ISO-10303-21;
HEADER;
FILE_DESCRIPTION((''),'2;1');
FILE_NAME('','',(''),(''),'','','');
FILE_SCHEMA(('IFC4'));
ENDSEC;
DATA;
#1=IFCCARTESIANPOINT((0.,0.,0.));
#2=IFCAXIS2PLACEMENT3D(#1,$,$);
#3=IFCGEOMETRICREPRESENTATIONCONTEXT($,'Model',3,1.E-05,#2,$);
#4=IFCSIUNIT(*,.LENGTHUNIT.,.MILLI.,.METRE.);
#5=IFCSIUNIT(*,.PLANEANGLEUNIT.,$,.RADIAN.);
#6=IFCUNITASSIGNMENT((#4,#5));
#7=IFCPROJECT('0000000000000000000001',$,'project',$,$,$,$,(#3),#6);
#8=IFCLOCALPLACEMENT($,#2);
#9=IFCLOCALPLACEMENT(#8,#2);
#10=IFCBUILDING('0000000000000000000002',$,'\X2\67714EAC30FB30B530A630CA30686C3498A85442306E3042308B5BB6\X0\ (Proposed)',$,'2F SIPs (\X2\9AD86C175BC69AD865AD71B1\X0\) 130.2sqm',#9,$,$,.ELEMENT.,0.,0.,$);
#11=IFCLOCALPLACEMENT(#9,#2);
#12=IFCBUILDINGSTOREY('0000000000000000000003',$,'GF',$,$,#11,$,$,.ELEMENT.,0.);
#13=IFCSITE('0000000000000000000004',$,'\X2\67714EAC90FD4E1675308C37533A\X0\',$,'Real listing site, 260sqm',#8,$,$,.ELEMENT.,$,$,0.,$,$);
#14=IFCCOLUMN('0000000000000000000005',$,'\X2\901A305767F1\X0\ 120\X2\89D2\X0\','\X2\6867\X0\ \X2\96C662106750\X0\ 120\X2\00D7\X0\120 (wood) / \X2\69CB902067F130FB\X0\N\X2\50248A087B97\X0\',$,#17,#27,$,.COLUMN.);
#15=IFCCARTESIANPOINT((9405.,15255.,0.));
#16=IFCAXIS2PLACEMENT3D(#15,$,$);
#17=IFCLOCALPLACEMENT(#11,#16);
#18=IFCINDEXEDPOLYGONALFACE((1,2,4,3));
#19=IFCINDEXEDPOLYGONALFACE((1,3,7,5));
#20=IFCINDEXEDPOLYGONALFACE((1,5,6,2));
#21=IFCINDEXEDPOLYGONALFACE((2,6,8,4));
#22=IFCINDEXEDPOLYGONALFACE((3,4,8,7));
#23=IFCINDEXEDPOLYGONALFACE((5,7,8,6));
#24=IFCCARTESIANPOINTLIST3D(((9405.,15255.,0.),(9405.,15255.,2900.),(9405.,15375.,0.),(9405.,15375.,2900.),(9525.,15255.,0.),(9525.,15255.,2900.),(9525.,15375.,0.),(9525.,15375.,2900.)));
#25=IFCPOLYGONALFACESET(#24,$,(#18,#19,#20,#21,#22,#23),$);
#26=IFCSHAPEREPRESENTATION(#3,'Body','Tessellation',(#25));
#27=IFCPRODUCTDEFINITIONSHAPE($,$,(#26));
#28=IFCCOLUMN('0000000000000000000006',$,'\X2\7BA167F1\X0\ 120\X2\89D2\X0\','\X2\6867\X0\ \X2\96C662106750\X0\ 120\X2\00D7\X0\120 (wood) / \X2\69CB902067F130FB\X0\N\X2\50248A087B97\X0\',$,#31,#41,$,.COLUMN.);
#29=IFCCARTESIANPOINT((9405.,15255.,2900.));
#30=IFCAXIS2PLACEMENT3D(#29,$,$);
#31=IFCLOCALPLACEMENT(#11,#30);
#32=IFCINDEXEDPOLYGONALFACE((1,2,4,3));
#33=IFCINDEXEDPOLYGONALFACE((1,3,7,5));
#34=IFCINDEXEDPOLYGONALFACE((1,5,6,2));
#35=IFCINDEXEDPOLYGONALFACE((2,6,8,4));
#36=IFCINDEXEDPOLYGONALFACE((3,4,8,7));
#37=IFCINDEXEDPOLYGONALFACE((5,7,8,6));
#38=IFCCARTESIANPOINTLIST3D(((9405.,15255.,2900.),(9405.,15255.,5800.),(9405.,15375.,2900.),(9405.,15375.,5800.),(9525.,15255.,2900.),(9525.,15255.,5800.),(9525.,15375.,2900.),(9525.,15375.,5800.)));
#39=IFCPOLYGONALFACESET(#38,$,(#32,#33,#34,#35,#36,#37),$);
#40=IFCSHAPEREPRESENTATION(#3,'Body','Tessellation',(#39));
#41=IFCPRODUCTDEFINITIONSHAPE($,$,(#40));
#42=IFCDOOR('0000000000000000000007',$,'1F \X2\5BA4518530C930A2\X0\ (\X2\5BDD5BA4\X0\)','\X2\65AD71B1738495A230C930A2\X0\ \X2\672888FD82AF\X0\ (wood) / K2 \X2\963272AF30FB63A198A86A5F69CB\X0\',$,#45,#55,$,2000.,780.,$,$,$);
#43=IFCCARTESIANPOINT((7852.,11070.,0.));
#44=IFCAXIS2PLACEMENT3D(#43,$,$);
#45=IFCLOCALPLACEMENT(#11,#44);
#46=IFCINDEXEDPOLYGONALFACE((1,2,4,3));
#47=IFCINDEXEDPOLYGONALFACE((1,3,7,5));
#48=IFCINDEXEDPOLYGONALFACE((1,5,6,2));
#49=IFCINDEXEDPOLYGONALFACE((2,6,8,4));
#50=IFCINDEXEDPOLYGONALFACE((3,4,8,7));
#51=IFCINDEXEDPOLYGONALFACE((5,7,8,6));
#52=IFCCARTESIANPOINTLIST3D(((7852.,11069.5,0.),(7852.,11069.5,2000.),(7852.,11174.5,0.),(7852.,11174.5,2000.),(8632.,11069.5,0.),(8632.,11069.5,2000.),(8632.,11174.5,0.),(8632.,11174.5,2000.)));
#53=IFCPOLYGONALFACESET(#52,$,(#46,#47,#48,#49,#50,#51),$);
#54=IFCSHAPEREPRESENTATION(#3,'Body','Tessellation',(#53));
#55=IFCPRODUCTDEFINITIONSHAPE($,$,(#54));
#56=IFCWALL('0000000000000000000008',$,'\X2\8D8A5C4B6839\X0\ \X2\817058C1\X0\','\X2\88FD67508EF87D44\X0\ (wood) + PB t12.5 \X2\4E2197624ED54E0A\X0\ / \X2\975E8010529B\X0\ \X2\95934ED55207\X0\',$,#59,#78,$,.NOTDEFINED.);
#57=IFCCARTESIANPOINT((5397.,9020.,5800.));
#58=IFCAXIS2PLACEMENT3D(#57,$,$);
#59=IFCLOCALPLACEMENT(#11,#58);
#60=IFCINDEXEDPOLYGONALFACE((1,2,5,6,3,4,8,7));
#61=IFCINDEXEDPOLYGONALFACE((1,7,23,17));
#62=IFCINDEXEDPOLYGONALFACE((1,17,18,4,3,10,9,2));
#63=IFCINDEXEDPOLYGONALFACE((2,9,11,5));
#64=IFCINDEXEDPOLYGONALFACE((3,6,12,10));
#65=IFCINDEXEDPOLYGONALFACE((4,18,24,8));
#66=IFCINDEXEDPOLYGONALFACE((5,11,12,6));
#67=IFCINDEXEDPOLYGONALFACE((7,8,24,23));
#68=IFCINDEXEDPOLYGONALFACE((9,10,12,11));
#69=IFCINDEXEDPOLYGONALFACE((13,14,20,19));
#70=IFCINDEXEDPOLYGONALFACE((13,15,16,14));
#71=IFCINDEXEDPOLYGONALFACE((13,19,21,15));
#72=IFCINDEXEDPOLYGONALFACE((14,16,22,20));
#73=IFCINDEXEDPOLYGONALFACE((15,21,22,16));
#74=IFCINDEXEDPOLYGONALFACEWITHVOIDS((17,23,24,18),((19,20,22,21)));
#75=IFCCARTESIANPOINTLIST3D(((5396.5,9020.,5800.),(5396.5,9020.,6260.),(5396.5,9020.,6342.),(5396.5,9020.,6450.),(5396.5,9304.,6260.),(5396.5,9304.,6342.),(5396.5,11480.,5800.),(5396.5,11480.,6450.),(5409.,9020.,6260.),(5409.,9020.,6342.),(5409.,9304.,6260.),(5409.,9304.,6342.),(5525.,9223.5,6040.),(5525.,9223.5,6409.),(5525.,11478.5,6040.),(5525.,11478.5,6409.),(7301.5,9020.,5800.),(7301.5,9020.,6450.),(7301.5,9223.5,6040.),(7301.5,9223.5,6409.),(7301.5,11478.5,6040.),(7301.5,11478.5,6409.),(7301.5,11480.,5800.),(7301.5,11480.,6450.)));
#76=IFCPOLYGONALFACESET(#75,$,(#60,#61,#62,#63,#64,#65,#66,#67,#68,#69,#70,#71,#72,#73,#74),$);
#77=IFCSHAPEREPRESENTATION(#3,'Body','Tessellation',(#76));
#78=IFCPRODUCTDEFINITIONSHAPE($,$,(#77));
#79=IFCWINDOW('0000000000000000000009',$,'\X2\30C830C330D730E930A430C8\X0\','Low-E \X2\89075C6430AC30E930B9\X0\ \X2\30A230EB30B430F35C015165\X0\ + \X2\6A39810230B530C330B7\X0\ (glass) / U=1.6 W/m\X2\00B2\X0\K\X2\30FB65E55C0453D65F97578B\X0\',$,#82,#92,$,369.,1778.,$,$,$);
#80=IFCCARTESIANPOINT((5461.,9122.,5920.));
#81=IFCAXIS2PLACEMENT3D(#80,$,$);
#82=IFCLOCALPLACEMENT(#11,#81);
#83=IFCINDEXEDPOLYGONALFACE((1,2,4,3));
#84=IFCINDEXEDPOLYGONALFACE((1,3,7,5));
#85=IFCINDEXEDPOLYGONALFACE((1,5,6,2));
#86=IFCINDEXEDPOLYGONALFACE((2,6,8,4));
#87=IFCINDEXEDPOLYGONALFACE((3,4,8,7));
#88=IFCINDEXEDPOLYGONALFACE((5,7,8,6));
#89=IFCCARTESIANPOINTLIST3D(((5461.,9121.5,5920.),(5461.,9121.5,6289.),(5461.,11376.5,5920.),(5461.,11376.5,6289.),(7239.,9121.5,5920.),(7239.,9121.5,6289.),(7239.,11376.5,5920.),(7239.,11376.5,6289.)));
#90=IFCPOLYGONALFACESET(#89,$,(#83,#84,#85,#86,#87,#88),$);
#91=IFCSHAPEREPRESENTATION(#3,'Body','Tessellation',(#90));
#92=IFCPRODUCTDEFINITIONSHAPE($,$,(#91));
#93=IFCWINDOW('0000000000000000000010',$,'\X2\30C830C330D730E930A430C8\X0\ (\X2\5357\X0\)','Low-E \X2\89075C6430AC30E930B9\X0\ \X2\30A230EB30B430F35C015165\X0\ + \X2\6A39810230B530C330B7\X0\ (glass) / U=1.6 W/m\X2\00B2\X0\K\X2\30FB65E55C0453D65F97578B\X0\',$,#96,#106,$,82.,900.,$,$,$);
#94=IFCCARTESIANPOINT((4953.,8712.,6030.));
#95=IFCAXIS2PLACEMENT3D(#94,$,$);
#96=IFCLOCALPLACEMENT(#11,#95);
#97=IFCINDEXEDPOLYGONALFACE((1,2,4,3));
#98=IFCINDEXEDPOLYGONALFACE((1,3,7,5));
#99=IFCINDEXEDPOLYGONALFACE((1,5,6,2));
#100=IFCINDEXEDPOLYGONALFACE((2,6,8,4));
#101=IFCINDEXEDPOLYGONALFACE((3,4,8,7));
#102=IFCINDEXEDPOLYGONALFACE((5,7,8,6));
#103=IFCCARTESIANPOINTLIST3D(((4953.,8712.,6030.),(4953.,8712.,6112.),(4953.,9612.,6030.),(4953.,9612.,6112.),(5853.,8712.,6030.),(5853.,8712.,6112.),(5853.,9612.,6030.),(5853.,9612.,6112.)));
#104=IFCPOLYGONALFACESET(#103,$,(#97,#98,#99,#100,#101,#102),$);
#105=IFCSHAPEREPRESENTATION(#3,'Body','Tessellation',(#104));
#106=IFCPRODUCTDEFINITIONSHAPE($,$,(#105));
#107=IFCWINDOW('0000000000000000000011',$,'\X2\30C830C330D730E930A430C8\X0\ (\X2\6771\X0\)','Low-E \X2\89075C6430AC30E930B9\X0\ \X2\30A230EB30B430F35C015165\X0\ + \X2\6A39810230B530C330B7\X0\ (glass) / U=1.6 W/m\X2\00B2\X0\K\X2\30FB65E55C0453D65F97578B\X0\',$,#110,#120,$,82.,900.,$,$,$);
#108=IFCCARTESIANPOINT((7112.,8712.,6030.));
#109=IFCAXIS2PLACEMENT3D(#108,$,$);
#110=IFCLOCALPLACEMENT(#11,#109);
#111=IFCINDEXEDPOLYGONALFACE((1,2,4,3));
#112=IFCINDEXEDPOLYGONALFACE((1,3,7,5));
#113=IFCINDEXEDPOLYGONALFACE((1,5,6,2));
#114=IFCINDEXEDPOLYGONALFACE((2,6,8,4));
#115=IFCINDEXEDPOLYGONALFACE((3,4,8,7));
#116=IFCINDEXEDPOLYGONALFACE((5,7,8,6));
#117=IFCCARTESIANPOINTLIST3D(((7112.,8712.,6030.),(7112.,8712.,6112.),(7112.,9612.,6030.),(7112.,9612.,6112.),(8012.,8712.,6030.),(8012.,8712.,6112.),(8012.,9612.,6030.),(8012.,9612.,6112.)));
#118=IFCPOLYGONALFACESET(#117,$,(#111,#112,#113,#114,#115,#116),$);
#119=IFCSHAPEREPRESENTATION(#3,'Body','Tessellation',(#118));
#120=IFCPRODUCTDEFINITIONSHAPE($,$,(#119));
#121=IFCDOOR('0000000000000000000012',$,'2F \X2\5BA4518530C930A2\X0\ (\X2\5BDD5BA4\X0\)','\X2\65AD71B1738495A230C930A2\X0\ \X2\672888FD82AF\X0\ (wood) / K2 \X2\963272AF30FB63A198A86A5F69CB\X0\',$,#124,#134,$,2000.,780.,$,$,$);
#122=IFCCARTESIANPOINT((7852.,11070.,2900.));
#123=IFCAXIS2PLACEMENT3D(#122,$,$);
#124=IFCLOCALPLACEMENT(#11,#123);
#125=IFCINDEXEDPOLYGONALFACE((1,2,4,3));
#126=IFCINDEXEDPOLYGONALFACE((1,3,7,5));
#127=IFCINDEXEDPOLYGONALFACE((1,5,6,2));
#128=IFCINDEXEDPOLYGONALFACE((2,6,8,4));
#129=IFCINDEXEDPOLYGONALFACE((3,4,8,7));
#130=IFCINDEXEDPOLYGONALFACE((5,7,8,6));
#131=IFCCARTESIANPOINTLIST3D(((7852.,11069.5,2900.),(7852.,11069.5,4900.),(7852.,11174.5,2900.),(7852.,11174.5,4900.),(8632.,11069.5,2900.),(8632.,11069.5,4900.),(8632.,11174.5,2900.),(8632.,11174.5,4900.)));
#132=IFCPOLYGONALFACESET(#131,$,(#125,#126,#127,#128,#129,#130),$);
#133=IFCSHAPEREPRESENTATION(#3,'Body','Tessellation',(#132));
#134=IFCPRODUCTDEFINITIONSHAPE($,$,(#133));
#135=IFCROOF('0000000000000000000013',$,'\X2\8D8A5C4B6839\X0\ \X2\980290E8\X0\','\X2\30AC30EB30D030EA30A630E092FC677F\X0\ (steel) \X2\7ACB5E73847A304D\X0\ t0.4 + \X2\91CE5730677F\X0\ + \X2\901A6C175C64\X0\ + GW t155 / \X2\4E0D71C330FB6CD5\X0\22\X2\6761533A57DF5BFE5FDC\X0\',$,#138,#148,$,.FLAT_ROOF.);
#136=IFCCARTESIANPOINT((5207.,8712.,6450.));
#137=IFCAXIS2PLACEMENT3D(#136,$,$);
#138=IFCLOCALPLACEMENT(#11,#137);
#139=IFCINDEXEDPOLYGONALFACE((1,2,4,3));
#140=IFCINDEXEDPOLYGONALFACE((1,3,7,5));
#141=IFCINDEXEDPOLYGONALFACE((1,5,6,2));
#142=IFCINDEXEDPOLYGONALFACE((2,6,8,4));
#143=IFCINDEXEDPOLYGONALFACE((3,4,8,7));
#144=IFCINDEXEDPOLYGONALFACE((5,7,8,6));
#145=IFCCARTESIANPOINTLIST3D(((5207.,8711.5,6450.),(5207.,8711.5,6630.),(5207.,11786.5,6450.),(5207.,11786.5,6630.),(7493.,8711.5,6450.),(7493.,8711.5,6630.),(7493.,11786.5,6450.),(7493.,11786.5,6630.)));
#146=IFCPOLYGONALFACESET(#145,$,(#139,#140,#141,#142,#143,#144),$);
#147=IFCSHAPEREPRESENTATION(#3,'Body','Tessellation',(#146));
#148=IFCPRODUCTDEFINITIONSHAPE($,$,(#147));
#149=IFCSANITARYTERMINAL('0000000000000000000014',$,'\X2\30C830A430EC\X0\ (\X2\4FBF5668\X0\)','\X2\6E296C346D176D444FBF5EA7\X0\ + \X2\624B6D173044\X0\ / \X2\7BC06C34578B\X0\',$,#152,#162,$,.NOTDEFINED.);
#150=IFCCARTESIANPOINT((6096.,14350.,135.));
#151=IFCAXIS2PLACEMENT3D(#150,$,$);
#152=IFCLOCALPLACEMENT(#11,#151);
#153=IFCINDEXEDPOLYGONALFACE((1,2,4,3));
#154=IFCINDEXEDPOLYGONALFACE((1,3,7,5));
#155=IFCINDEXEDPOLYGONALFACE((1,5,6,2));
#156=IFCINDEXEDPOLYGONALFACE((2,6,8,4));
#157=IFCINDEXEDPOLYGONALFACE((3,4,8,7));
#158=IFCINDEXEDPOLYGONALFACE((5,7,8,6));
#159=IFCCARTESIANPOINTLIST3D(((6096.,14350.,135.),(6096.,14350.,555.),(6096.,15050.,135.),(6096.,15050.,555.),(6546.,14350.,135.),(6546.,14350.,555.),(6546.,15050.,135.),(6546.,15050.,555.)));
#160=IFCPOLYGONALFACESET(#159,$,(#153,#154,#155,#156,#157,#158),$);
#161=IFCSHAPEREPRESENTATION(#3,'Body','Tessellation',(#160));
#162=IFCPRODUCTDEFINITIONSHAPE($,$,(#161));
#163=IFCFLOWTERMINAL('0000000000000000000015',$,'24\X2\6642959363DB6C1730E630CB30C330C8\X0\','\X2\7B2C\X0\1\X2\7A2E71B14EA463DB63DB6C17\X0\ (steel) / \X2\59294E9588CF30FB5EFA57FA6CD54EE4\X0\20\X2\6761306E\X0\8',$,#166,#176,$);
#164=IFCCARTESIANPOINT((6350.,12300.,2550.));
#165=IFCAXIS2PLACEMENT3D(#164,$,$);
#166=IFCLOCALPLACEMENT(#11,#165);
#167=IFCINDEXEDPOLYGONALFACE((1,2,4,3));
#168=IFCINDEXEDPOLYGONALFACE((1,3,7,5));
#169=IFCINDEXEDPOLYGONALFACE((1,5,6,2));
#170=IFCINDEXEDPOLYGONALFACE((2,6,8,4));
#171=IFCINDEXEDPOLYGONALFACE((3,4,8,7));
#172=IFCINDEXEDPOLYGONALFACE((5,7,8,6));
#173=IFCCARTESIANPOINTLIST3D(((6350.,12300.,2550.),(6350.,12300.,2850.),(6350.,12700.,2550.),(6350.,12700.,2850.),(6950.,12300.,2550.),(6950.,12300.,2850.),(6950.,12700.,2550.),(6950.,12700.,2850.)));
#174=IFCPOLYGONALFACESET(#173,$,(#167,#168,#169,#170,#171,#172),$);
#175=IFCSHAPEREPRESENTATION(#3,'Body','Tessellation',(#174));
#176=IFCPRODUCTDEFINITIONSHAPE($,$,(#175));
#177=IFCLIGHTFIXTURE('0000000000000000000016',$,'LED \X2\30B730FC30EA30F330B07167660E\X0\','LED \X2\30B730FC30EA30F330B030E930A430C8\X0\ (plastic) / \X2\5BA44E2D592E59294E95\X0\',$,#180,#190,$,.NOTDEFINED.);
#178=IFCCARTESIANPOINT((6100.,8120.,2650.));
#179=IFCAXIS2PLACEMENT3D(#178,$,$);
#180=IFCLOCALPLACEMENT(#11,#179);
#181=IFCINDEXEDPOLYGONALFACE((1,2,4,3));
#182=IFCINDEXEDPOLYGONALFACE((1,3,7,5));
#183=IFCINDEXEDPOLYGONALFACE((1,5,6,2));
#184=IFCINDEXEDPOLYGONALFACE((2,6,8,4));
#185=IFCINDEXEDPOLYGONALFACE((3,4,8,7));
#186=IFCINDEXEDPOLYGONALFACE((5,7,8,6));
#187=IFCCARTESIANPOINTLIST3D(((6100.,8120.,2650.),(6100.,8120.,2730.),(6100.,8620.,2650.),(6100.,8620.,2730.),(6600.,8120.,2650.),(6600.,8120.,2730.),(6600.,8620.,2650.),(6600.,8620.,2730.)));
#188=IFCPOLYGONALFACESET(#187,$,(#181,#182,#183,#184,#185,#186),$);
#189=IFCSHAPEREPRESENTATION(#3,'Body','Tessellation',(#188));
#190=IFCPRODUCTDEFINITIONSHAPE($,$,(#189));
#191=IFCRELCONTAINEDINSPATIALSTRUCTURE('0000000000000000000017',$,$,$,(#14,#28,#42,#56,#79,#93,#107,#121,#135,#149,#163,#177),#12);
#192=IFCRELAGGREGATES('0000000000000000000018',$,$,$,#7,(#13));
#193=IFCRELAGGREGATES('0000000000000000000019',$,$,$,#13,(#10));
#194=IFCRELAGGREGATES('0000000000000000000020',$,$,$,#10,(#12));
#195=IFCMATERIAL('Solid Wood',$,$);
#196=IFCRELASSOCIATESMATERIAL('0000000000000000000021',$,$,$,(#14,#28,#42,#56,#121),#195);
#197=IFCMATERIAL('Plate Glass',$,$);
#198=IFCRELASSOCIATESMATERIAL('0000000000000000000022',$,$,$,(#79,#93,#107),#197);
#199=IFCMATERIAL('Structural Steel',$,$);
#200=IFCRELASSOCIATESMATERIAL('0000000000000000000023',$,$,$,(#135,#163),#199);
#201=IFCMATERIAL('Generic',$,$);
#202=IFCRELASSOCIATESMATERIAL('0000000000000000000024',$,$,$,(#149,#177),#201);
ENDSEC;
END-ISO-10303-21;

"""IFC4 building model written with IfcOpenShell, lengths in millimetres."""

from ifc_helpers import new_model, si_unit, frame, frame_2d, origin, place, context, project, spatial, rectangle, extrude, material, element, fill, save


model = new_model("IFC4")

# Units and contexts
model_context = context("Model", 3, precision=1e-05, world=origin())
ifc_project = project(units=[si_unit("LENGTHUNIT", "METRE", prefix="MILLI"), si_unit("PLANEANGLEUNIT", "RADIAN")], contexts=[model_context])

# Site, building, storey
site_placement = place(None, origin())
site = spatial("IfcSite", under=ifc_project, at=site_placement, Name="東京都世田谷区", ObjectType="Real listing site, 260sqm", CompositionType="ELEMENT", RefElevation=0.0)
building_placement = place(site_placement, origin())
building = spatial("IfcBuilding", under=site, at=building_placement, Name="東京・サウナと水風呂のある家 (Proposed)", ObjectType="2F SIPs (高気密高断熱) 130.2sqm", CompositionType="ELEMENT", ElevationOfRefHeight=0.0, ElevationOfTerrain=0.0)
storey_placement = place(building_placement, origin())
storey = spatial("IfcBuildingStorey", under=building, at=storey_placement, Name="GF", CompositionType="ELEMENT", Elevation=0.0)

# Columns
ifc_material_1 = material(Name="Solid Wood")
column_1_placement = place(storey_placement, frame((9405.0, 15255.0, 0.0)))
element("IfcColumn", 1, at=column_1_placement, inside=storey, material=ifc_material_1, Name="通し柱 120角", Description="桧 集成材 120×120 (wood) / 構造柱・N値計算", PredefinedType="COLUMN", context=model_context, shape_type="SweptSolid", body=[
    extrude(rectangle(XDim=120.0, YDim=120.0, at=frame_2d((60.0, 60.0))), frame((9405.0, 15255.0, 0.0)), (0.0, 0.0, 1.0), 2900.0),
])
column_2_placement = place(storey_placement, frame((9405.0, 15255.0, 2900.0)))
element("IfcColumn", 2, at=column_2_placement, inside=storey, material=ifc_material_1, Name="管柱 120角", Description="桧 集成材 120×120 (wood) / 構造柱・N値計算", PredefinedType="COLUMN", context=model_context, shape_type="SweptSolid", body=[
    extrude(rectangle(XDim=120.0, YDim=120.0, at=frame_2d((60.0, 60.0))), frame((9405.0, 15255.0, 2900.0)), (0.0, 0.0, 1.0), 2900.0),
])

# Door
door_1_placement = place(storey_placement, frame((7852.0, 11070.0, 0.0)))
element("IfcDoor", 3, at=door_1_placement, inside=storey, material=ifc_material_1, Name="1F 室内ドア (寝室)", Description="断熱玄関ドア 木製芯 (wood) / K2 防犯・採風機構", OverallHeight=2000.0, OverallWidth=780.0, context=model_context, shape_type="SweptSolid", body=[
    extrude(rectangle(XDim=780.0, YDim=105.0, at=frame_2d((390.0, 52.0))), frame((7852.0, 11070.0, 0.0)), (0.0, 0.0, 1.0), 2000.0),
])

# Wall, openings, windows
wall_1_placement = place(storey_placement, frame((5397.0, 9020.0, 5800.0)))
wall_1 = element("IfcWall", 4, at=wall_1_placement, inside=storey, material=ifc_material_1, Name="越屋根 腰壁", Description="製材軸組 (wood) + PB t12.5 両面仕上 / 非耐力 間仕切", PredefinedType="NOTDEFINED", context=model_context, shape_type="SweptSolid", body=[
    extrude(rectangle(XDim=1905.0, YDim=2460.0, at=frame_2d((952.0, 1230.0))), frame((5397.0, 9020.0, 5800.0)), (0.0, 0.0, 1.0), 650.0),
])
opening_1_placement = place(storey_placement, frame((5461.0, 9122.0, 5920.0)))
opening_1 = element("IfcOpeningElement", 5, at=opening_1_placement, cuts=wall_1, PredefinedType="NOTDEFINED", context=model_context, shape_type="SweptSolid", body=[
    extrude(rectangle(XDim=1778.0, YDim=2255.0, at=frame_2d((889.0, 1127.0))), frame((5461.0, 9122.0, 5920.0)), (0.0, 0.0, 1.0), 369.0),
])
opening_2_placement = place(storey_placement, frame((4953.0, 8712.0, 6030.0)))
opening_2 = element("IfcOpeningElement", 6, at=opening_2_placement, cuts=wall_1, PredefinedType="NOTDEFINED", context=model_context, shape_type="SweptSolid", body=[
    extrude(rectangle(XDim=900.0, YDim=900.0, at=frame_2d((450.0, 450.0))), frame((4953.0, 8712.0, 6030.0)), (0.0, 0.0, 1.0), 82.0),
])
opening_3_placement = place(storey_placement, frame((7112.0, 8712.0, 6030.0)))
opening_3 = element("IfcOpeningElement", 7, at=opening_3_placement, cuts=wall_1, PredefinedType="NOTDEFINED", context=model_context, shape_type="SweptSolid", body=[
    extrude(rectangle(XDim=900.0, YDim=900.0, at=frame_2d((450.0, 450.0))), frame((7112.0, 8712.0, 6030.0)), (0.0, 0.0, 1.0), 82.0),
])
ifc_material_2 = material(Name="Plate Glass")
window_1_placement = place(storey_placement, frame((5461.0, 9122.0, 5920.0)))
window_1 = element("IfcWindow", 8, at=window_1_placement, inside=storey, material=ifc_material_2, Name="トップライト", Description="Low-E 複層ガラス アルゴン封入 + 樹脂サッシ (glass) / U=1.6 W/m²K・日射取得型", OverallHeight=369.0, OverallWidth=1778.0, context=model_context, shape_type="SweptSolid", body=[
    extrude(rectangle(XDim=1778.0, YDim=2255.0, at=frame_2d((889.0, 1127.0))), frame((5461.0, 9122.0, 5920.0)), (0.0, 0.0, 1.0), 369.0),
])
fill(opening_1, window_1)
window_2_placement = place(storey_placement, frame((4953.0, 8712.0, 6030.0)))
window_2 = element("IfcWindow", 9, at=window_2_placement, inside=storey, material=ifc_material_2, Name="トップライト (南)", Description="Low-E 複層ガラス アルゴン封入 + 樹脂サッシ (glass) / U=1.6 W/m²K・日射取得型", OverallHeight=82.0, OverallWidth=900.0, context=model_context, shape_type="SweptSolid", body=[
    extrude(rectangle(XDim=900.0, YDim=900.0, at=frame_2d((450.0, 450.0))), frame((4953.0, 8712.0, 6030.0)), (0.0, 0.0, 1.0), 82.0),
])
fill(opening_2, window_2)
window_3_placement = place(storey_placement, frame((7112.0, 8712.0, 6030.0)))
window_3 = element("IfcWindow", 10, at=window_3_placement, inside=storey, material=ifc_material_2, Name="トップライト (東)", Description="Low-E 複層ガラス アルゴン封入 + 樹脂サッシ (glass) / U=1.6 W/m²K・日射取得型", OverallHeight=82.0, OverallWidth=900.0, context=model_context, shape_type="SweptSolid", body=[
    extrude(rectangle(XDim=900.0, YDim=900.0, at=frame_2d((450.0, 450.0))), frame((7112.0, 8712.0, 6030.0)), (0.0, 0.0, 1.0), 82.0),
])
fill(opening_3, window_3)

# Door
door_2_placement = place(storey_placement, frame((7852.0, 11070.0, 2900.0)))
element("IfcDoor", 11, at=door_2_placement, inside=storey, material=ifc_material_1, Name="2F 室内ドア (寝室)", Description="断熱玄関ドア 木製芯 (wood) / K2 防犯・採風機構", OverallHeight=2000.0, OverallWidth=780.0, context=model_context, shape_type="SweptSolid", body=[
    extrude(rectangle(XDim=780.0, YDim=105.0, at=frame_2d((390.0, 52.0))), frame((7852.0, 11070.0, 2900.0)), (0.0, 0.0, 1.0), 2000.0),
])

# Roof
ifc_material_3 = material(Name="Structural Steel")
roof_placement = place(storey_placement, frame((5207.0, 8712.0, 6450.0)))
element("IfcRoof", 12, at=roof_placement, inside=storey, material=ifc_material_3, Name="越屋根 頂部", Description="ガルバリウム鋼板 (steel) 立平葺き t0.4 + 野地板 + 通気層 + GW t155 / 不燃・法22条区域対応", PredefinedType="FLAT_ROOF", context=model_context, shape_type="SweptSolid", body=[
    extrude(rectangle(XDim=2286.0, YDim=3075.0, at=frame_2d((1143.0, 1537.0))), frame((5207.0, 8712.0, 6450.0)), (0.0, 0.0, 1.0), 180.0),
])

# Sanitary terminal
ifc_material_4 = material(Name="Generic")
sanitary_terminal_placement = place(storey_placement, frame((6096.0, 14350.0, 135.0)))
element("IfcSanitaryTerminal", 13, at=sanitary_terminal_placement, inside=storey, material=ifc_material_4, Name="トイレ (便器)", Description="温水洗浄便座 + 手洗い / 節水型", PredefinedType="NOTDEFINED", context=model_context, shape_type="SweptSolid", body=[
    extrude(rectangle(XDim=450.0, YDim=700.0, at=frame_2d((225.0, 350.0))), frame((6096.0, 14350.0, 135.0)), (0.0, 0.0, 1.0), 420.0),
])

# Flow terminal
flow_terminal_placement = place(storey_placement, frame((6350.0, 12300.0, 2550.0)))
element("IfcFlowTerminal", 14, at=flow_terminal_placement, inside=storey, material=ifc_material_3, Name="24時間換気ユニット", Description="第1種熱交換換気 (steel) / 天井裏・建基法令20条の8", context=model_context, shape_type="SweptSolid", body=[
    extrude(rectangle(XDim=600.0, YDim=400.0, at=frame_2d((300.0, 200.0))), frame((6350.0, 12300.0, 2550.0)), (0.0, 0.0, 1.0), 300.0),
])

# Light fixture
light_fixture_1_placement = place(storey_placement, frame((6100.0, 8120.0, 2650.0)))
element("IfcLightFixture", 15, at=light_fixture_1_placement, inside=storey, material=ifc_material_4, Name="LED シーリング照明", Description="LED シーリングライト (plastic) / 室中央天井", PredefinedType="NOTDEFINED", context=model_context, shape_type="SweptSolid", body=[
    extrude(rectangle(XDim=500.0, YDim=500.0, at=frame_2d((250.0, 250.0))), frame((6100.0, 8120.0, 2650.0)), (0.0, 0.0, 1.0), 80.0),
])

save(model, "model.ifc")
